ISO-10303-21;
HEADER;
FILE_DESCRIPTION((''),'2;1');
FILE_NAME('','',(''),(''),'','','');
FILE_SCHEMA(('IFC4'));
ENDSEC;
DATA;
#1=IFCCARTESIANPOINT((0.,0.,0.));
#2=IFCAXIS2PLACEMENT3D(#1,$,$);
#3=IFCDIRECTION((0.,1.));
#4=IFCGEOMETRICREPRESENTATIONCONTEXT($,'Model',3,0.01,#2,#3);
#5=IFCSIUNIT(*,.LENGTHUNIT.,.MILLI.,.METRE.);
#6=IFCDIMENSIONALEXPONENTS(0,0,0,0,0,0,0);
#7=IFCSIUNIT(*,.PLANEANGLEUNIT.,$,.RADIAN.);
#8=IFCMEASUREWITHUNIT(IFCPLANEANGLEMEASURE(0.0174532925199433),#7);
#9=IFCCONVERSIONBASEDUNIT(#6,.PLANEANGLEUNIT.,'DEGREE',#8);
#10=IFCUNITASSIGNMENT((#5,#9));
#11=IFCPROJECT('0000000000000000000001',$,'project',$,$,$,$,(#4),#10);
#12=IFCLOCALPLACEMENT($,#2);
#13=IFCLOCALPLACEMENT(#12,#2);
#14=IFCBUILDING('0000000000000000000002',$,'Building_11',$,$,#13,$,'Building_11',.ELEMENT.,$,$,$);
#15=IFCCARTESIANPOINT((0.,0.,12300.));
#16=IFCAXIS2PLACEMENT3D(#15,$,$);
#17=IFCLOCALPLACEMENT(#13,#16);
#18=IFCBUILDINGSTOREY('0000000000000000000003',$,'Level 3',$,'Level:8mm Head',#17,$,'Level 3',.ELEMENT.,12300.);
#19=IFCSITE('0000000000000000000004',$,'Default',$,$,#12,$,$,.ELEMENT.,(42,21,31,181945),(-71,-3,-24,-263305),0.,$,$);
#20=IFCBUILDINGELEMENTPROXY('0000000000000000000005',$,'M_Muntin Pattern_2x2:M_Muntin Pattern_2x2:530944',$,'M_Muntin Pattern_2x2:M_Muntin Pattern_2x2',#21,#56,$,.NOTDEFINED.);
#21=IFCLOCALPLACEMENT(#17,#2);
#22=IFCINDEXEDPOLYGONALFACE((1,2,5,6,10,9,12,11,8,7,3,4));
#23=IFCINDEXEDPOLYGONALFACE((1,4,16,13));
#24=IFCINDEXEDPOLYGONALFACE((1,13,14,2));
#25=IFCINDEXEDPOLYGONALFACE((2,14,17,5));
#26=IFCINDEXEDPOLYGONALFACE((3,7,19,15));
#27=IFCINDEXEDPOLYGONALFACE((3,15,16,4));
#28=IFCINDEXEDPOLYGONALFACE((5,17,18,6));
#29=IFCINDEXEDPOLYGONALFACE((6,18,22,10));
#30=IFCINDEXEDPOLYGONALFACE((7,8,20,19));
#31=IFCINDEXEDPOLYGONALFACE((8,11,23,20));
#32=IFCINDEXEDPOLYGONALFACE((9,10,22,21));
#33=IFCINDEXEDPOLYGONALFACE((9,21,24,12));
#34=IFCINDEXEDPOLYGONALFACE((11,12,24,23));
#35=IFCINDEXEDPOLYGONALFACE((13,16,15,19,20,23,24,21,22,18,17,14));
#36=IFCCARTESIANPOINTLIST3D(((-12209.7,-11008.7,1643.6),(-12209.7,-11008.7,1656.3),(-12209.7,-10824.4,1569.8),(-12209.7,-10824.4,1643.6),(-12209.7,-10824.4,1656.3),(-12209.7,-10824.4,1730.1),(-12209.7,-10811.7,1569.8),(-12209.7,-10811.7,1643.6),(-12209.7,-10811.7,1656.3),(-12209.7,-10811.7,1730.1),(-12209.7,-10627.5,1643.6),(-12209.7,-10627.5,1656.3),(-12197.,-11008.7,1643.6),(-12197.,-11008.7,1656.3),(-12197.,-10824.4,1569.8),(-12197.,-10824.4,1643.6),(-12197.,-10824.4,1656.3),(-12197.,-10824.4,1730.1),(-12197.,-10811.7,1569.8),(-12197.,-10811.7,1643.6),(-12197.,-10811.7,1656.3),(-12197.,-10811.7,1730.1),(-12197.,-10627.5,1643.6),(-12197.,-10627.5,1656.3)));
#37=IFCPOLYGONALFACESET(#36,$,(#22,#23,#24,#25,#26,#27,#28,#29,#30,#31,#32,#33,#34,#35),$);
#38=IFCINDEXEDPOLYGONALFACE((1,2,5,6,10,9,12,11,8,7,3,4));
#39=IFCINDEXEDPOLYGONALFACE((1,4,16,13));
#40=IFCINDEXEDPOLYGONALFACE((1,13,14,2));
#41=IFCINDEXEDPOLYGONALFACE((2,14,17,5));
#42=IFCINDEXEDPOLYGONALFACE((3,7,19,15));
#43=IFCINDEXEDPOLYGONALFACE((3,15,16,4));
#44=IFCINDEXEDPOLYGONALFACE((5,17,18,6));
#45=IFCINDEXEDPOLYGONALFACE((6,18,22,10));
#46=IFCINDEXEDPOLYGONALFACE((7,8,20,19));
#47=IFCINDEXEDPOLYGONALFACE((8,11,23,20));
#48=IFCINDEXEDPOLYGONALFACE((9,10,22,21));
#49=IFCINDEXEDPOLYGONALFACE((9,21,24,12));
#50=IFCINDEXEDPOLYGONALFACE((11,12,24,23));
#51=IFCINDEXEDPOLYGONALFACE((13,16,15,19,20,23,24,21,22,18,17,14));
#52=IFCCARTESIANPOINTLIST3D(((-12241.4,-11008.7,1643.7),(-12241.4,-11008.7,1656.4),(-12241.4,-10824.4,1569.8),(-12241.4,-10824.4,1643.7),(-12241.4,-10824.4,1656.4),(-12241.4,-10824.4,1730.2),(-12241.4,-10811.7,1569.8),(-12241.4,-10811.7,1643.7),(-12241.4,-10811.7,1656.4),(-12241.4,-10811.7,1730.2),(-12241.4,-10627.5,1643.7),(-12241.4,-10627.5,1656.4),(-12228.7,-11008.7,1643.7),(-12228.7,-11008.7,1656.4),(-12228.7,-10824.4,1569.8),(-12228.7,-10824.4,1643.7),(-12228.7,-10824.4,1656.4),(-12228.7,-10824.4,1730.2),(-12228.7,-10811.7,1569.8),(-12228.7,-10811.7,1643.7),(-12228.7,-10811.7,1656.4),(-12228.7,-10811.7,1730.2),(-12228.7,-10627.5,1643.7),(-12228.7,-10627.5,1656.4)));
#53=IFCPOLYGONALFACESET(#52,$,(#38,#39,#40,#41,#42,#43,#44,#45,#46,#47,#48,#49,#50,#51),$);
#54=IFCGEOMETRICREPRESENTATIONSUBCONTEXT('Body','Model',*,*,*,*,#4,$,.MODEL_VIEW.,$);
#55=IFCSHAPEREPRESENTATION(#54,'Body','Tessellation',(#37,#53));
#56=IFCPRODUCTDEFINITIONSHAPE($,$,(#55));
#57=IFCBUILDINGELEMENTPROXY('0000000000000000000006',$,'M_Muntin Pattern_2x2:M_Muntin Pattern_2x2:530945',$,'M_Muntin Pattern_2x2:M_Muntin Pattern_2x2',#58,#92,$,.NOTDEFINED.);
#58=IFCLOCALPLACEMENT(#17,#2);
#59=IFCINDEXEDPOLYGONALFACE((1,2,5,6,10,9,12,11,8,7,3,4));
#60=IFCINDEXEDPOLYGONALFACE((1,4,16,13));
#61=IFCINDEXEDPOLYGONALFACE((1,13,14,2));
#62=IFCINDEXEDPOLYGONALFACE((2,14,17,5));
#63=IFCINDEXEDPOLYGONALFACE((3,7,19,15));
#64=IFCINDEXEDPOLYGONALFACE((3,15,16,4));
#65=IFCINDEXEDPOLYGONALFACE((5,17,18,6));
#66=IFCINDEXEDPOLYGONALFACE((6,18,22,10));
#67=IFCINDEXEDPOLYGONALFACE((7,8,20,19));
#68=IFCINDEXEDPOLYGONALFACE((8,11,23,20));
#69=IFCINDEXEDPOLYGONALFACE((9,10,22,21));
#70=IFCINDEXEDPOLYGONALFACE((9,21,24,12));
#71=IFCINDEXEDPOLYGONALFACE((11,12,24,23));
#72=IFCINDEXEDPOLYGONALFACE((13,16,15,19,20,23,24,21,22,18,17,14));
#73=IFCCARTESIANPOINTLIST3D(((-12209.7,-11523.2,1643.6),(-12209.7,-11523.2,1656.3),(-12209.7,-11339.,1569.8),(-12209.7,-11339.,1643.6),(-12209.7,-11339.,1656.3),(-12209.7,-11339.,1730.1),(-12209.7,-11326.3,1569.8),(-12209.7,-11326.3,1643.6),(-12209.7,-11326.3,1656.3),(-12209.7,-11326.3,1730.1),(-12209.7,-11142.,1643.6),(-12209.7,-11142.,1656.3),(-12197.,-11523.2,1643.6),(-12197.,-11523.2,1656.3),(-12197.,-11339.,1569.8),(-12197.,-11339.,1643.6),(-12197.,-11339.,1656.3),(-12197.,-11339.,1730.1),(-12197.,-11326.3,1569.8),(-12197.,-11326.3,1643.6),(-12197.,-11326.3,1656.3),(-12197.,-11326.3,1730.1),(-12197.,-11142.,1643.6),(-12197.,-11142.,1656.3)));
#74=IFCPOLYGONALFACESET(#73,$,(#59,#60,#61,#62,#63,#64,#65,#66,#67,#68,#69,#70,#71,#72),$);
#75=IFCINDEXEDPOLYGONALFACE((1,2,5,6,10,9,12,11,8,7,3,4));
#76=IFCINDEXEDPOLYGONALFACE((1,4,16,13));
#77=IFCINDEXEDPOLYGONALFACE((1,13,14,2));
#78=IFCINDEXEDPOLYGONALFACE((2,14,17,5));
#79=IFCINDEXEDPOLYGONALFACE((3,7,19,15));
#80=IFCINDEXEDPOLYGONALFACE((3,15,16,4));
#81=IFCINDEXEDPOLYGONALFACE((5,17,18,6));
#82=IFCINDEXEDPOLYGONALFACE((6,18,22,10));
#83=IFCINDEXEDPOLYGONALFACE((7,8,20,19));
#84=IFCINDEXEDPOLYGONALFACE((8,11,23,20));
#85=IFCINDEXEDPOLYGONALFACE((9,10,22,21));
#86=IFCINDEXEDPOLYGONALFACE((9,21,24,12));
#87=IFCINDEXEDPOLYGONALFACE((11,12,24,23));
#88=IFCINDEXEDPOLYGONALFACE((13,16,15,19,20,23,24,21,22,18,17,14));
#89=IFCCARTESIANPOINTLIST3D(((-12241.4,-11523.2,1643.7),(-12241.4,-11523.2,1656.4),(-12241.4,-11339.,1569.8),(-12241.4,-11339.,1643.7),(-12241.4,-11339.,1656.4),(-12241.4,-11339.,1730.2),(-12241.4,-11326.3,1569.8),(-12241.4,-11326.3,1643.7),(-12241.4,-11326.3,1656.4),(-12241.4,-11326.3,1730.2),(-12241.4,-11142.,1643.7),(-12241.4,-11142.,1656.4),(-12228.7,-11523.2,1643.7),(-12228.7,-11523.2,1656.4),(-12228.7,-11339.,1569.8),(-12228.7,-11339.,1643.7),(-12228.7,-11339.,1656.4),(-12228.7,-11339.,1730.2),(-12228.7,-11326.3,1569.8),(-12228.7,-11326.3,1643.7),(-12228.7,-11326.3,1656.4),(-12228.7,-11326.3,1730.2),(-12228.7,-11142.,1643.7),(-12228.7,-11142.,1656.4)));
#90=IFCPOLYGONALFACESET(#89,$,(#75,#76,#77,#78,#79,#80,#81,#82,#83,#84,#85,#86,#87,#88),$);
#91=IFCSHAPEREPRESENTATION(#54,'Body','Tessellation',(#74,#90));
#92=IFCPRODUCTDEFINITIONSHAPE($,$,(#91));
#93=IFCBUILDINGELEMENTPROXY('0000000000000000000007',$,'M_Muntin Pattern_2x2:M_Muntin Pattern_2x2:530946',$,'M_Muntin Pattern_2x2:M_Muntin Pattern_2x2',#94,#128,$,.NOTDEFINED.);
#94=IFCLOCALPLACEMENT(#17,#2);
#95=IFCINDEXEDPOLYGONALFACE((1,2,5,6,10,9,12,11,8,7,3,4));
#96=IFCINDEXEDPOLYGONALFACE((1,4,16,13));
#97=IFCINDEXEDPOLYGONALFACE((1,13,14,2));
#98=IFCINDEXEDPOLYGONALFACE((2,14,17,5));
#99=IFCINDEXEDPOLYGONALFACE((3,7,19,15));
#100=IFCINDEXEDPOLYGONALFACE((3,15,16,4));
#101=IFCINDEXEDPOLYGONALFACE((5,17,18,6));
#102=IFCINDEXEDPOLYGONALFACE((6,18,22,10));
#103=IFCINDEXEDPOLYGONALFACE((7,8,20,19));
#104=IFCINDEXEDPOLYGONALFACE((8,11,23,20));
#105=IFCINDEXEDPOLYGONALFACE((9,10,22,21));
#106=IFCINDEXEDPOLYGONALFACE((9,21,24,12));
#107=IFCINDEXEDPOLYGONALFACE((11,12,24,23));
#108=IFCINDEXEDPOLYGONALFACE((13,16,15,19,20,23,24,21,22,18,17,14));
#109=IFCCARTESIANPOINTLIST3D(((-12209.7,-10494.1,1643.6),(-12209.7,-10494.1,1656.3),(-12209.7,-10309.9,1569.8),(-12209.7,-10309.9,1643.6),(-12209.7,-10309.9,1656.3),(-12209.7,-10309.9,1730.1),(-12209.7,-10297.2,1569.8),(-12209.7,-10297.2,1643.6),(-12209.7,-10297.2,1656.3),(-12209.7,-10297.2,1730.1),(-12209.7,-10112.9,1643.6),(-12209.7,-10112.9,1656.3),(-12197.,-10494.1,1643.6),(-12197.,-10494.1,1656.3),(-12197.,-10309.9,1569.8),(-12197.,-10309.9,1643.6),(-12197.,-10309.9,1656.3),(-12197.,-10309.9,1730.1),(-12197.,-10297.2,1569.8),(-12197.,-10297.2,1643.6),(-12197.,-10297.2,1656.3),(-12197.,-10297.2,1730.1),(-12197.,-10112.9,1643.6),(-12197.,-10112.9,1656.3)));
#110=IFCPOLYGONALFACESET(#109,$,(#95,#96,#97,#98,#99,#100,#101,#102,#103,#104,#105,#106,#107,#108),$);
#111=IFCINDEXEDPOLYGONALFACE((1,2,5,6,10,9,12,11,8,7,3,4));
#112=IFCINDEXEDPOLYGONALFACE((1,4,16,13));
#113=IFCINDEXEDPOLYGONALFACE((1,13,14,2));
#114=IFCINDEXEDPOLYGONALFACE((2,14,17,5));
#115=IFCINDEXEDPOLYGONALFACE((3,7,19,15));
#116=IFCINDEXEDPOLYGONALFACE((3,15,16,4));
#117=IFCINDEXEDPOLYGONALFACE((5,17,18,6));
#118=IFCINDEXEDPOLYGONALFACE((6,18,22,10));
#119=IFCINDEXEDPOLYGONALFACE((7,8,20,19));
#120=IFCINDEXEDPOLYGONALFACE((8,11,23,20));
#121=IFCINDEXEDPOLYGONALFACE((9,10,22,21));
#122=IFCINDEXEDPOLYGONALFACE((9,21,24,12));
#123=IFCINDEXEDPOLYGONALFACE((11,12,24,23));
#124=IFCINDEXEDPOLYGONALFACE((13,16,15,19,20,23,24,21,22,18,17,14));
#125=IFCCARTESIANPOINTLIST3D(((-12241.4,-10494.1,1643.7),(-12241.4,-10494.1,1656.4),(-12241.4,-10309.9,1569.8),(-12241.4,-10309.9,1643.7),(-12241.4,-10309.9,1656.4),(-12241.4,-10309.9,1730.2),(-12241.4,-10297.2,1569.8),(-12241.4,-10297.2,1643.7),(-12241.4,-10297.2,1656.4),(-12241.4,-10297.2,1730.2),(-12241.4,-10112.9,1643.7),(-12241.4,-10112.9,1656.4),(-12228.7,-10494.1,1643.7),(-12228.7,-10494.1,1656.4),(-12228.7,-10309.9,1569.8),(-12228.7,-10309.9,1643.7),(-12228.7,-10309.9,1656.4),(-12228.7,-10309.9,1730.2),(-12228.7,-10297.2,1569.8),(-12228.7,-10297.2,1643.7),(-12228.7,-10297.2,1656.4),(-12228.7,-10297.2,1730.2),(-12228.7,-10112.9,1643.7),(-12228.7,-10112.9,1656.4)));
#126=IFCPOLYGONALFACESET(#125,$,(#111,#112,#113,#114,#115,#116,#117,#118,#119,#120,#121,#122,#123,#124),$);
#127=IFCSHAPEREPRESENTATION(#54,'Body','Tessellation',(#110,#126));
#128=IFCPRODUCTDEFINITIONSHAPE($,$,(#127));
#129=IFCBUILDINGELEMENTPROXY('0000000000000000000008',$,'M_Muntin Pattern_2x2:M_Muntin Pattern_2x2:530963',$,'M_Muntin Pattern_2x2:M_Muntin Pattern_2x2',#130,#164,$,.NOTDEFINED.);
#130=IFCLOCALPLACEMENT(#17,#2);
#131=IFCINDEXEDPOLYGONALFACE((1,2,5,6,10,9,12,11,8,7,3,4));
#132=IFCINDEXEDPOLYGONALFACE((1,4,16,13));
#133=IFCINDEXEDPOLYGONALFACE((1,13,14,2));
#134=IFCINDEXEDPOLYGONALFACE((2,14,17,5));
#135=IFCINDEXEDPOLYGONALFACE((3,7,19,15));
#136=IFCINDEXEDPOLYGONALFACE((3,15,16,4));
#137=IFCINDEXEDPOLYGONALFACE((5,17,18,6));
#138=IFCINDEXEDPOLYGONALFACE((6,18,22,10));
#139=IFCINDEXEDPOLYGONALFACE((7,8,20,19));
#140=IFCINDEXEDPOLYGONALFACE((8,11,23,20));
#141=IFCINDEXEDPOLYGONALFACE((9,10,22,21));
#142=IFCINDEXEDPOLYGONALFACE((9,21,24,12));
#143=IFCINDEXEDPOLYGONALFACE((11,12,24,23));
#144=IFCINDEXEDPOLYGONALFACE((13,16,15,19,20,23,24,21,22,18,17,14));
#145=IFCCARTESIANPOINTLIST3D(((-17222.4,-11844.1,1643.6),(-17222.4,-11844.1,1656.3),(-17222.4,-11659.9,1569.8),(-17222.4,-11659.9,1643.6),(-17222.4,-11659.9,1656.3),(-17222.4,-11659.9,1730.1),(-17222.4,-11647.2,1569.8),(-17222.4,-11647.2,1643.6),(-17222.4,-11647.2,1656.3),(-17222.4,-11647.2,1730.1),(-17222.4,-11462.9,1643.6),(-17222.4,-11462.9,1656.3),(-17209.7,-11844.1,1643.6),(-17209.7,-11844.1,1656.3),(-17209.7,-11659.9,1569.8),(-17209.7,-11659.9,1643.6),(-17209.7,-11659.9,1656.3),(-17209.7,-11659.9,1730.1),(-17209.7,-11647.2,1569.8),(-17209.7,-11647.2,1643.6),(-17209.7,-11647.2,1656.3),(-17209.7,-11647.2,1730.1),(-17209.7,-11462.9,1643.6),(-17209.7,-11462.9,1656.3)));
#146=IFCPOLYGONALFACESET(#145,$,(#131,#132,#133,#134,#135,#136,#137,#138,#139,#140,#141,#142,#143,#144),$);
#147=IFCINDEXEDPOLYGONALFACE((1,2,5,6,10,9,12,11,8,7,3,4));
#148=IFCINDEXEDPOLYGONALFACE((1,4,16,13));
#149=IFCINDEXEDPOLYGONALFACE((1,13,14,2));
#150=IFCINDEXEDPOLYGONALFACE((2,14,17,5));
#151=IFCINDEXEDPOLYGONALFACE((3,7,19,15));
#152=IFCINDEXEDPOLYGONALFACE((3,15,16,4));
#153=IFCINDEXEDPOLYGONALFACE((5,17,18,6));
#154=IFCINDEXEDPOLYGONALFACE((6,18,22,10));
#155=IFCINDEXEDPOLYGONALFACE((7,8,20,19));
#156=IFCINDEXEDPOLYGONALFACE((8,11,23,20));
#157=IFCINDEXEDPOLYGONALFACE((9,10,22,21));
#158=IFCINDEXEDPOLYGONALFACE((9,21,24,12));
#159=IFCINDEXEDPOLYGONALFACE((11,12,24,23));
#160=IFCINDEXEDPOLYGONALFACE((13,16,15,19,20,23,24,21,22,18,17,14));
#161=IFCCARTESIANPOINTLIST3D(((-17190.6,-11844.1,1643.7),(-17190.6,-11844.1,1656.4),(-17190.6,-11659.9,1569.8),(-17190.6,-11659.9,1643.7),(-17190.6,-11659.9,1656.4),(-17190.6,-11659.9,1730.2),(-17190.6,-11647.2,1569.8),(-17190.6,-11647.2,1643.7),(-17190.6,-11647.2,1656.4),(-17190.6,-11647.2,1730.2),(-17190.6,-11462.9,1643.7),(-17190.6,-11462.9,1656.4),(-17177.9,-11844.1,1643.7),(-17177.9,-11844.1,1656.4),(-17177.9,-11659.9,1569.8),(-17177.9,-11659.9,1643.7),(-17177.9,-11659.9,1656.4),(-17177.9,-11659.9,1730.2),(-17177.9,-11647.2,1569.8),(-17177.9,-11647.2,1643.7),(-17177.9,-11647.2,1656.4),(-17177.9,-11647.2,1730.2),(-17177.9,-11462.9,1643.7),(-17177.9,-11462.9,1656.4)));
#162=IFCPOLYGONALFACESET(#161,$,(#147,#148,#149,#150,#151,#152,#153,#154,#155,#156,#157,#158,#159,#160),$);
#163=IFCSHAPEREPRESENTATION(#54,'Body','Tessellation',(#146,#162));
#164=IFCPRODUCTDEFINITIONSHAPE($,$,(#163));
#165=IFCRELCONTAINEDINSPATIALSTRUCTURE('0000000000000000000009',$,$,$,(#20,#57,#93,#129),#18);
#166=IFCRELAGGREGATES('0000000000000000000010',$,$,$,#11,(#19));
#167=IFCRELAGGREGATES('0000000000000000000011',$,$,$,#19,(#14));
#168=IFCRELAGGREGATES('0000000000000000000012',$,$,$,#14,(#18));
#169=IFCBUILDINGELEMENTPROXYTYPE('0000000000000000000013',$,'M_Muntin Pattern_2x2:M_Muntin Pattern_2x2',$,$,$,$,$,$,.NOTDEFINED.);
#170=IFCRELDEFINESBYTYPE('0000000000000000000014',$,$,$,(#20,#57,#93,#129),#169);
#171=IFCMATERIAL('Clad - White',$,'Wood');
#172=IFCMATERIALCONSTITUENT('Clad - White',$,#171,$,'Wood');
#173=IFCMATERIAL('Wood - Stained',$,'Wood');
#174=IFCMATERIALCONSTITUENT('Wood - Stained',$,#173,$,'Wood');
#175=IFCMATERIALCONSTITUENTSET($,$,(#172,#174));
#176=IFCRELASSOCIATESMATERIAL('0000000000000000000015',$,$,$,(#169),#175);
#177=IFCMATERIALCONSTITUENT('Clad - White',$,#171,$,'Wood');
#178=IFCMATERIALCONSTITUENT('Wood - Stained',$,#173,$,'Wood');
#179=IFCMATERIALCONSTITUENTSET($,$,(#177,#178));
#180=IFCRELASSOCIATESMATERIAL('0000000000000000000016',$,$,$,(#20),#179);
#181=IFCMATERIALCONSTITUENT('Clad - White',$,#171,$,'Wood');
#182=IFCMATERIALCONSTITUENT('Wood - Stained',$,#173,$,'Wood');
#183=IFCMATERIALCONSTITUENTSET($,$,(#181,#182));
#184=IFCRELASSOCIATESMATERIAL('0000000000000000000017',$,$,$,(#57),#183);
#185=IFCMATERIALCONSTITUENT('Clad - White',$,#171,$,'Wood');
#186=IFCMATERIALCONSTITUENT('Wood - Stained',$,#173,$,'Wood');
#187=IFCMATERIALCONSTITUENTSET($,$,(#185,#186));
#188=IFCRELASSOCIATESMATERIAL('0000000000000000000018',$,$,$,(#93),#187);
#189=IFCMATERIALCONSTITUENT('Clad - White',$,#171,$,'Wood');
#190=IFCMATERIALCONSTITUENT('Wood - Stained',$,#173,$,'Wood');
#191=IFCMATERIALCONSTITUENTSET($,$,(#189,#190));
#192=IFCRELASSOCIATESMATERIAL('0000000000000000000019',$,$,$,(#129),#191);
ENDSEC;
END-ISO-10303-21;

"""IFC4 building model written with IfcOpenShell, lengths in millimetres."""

from ifc_helpers import new_model, entity, si_unit, converted_unit, direction, frame, origin, place, context, subcontext, project, spatial, indexed_curve, outline, extrude, source, transform, mapped, material, constituent, constituent_set, type_object, type_shapes, element, save


model = new_model("IFC4")

# Units and contexts
model_context = context("Model", 3, precision=0.01, world=origin(), true_north=direction((0.0, 1.0)))
body_context = subcontext(model_context, "Body", "Model", "MODEL_VIEW")
ifc_project = project(units=[si_unit("LENGTHUNIT", "METRE", prefix="MILLI"), converted_unit("PLANEANGLEUNIT", "DEGREE", entity("IfcPlaneAngleMeasure", 0.0174532925199433), si_unit("PLANEANGLEUNIT", "RADIAN"), dimensions=[0, 0, 0, 0, 0, 0, 0])], contexts=[model_context])

# Site, building, storey
site_placement = place(None, origin())
site = spatial("IfcSite", under=ifc_project, at=site_placement, Name="Default", CompositionType="ELEMENT", RefLatitude=(42, 21, 31, 181945), RefLongitude=(-71, -3, -24, -263305), RefElevation=0.0)
building_placement = place(site_placement, origin())
building = spatial("IfcBuilding", under=site, at=building_placement, Name="Building_11", LongName="Building_11", CompositionType="ELEMENT")
storey_placement = place(building_placement, frame((0.0, 0.0, 12300.0)))
storey = spatial("IfcBuildingStorey", under=building, at=storey_placement, Name="Level 3", ObjectType="Level:8mm Head", LongName="Level 3", CompositionType="ELEMENT", Elevation=12300.0)

# Building element proxies
ifc_material_1 = material(Name="Clad - White", Category="Wood")
ifc_material_2 = material(Name="Wood - Stained", Category="Wood")
ifc_constituent_1 = constituent(ifc_material_1, Name="Clad - White", Category="Wood")
ifc_constituent_2 = constituent(ifc_material_2, Name="Wood - Stained", Category="Wood")
ifc_constituent_set_1 = constituent_set(constituents=[ifc_constituent_1, ifc_constituent_2])
building_element_proxy_type_1 = type_object("IfcBuildingElementProxyType", Name="M_Muntin Pattern_2x2:M_Muntin Pattern_2x2", PredefinedType="NOTDEFINED", material=ifc_constituent_set_1)
shared_shape_1 = source(origin(), body_context, "Body", "SweptSolid", [
    extrude(outline(indexed_curve([(6.4, -6.4), (80.1, -6.4), (80.1, 6.3), (6.4, 6.3), (6.4, 190.6), (-6.3, 190.6), (-6.3, 6.3), (-80.2, 6.3), (-80.2, -6.4), (-6.3, -6.4), (-6.3, -190.6), (6.4, -190.6), (6.4, -6.4)], self_intersect=False)), frame((0.0, 9.5, 80.1), z_axis=(0.0, 1.0, 0.0), x_axis=(0.0, 0.0, 1.0)), (0.0, 0.0, 1.0), 12.7),
    extrude(outline(indexed_curve([(6.4, -6.4), (80.2, -6.4), (80.2, 6.3), (6.4, 6.3), (6.4, 190.6), (-6.3, 190.6), (-6.3, 6.3), (-80.2, 6.3), (-80.2, -6.4), (-6.3, -6.4), (-6.3, -190.6), (6.4, -190.6), (6.4, -6.4)], self_intersect=False)), frame((0.0, -22.2, 80.2), z_axis=(0.0, 1.0, 0.0), x_axis=(0.0, 0.0, 1.0)), (0.0, 0.0, 1.0), 12.7),
])
type_shapes(building_element_proxy_type_1, [shared_shape_1])
ifc_constituent_3 = constituent(ifc_material_1, Name="Clad - White", Category="Wood")
ifc_constituent_4 = constituent(ifc_material_2, Name="Wood - Stained", Category="Wood")
ifc_constituent_set_2 = constituent_set(constituents=[ifc_constituent_3, ifc_constituent_4])
proxy_1_placement = place(storey_placement, frame((-12219.2, -10818.1, 1569.8), z_axis=(0.0, 0.0, 1.0), x_axis=(0.0, -1.0, 0.0)))
element("IfcBuildingElementProxy", 1, at=proxy_1_placement, inside=storey, type_object=building_element_proxy_type_1, material=ifc_constituent_set_2, Name="M_Muntin Pattern_2x2:M_Muntin Pattern_2x2:530944", ObjectType="M_Muntin Pattern_2x2:M_Muntin Pattern_2x2", PredefinedType="NOTDEFINED", context=body_context, shape_type="MappedRepresentation", body=[
    mapped(shared_shape_1, transform((0.0, 0.0, 0.0), scale=1.0)),
])
ifc_constituent_5 = constituent(ifc_material_1, Name="Clad - White", Category="Wood")
ifc_constituent_6 = constituent(ifc_material_2, Name="Wood - Stained", Category="Wood")
ifc_constituent_set_3 = constituent_set(constituents=[ifc_constituent_5, ifc_constituent_6])
proxy_2_placement = place(storey_placement, frame((-12219.2, -11332.6, 1569.8), z_axis=(0.0, 0.0, 1.0), x_axis=(0.0, -1.0, 0.0)))
element("IfcBuildingElementProxy", 2, at=proxy_2_placement, inside=storey, type_object=building_element_proxy_type_1, material=ifc_constituent_set_3, Name="M_Muntin Pattern_2x2:M_Muntin Pattern_2x2:530945", ObjectType="M_Muntin Pattern_2x2:M_Muntin Pattern_2x2", PredefinedType="NOTDEFINED", context=body_context, shape_type="MappedRepresentation", body=[
    mapped(shared_shape_1, transform((0.0, 0.0, 0.0), scale=1.0)),
])
ifc_constituent_7 = constituent(ifc_material_1, Name="Clad - White", Category="Wood")
ifc_constituent_8 = constituent(ifc_material_2, Name="Wood - Stained", Category="Wood")
ifc_constituent_set_4 = constituent_set(constituents=[ifc_constituent_7, ifc_constituent_8])
proxy_3_placement = place(storey_placement, frame((-12219.2, -10303.5, 1569.8), z_axis=(0.0, 0.0, 1.0), x_axis=(0.0, -1.0, 0.0)))
element("IfcBuildingElementProxy", 3, at=proxy_3_placement, inside=storey, type_object=building_element_proxy_type_1, material=ifc_constituent_set_4, Name="M_Muntin Pattern_2x2:M_Muntin Pattern_2x2:530946", ObjectType="M_Muntin Pattern_2x2:M_Muntin Pattern_2x2", PredefinedType="NOTDEFINED", context=body_context, shape_type="MappedRepresentation", body=[
    mapped(shared_shape_1, transform((0.0, 0.0, 0.0), scale=1.0)),
])
ifc_constituent_9 = constituent(ifc_material_1, Name="Clad - White", Category="Wood")
ifc_constituent_10 = constituent(ifc_material_2, Name="Wood - Stained", Category="Wood")
ifc_constituent_set_5 = constituent_set(constituents=[ifc_constituent_9, ifc_constituent_10])
proxy_4_placement = place(storey_placement, frame((-17200.2, -11653.5, 1569.8), z_axis=(0.0, 0.0, 1.0), x_axis=(0.0, 1.0, 0.0)))
element("IfcBuildingElementProxy", 4, at=proxy_4_placement, inside=storey, type_object=building_element_proxy_type_1, material=ifc_constituent_set_5, Name="M_Muntin Pattern_2x2:M_Muntin Pattern_2x2:530963", ObjectType="M_Muntin Pattern_2x2:M_Muntin Pattern_2x2", PredefinedType="NOTDEFINED", context=body_context, shape_type="MappedRepresentation", body=[
    mapped(shared_shape_1, transform((0.0, 0.0, 0.0), scale=1.0)),
])

save(model, "model.ifc")
